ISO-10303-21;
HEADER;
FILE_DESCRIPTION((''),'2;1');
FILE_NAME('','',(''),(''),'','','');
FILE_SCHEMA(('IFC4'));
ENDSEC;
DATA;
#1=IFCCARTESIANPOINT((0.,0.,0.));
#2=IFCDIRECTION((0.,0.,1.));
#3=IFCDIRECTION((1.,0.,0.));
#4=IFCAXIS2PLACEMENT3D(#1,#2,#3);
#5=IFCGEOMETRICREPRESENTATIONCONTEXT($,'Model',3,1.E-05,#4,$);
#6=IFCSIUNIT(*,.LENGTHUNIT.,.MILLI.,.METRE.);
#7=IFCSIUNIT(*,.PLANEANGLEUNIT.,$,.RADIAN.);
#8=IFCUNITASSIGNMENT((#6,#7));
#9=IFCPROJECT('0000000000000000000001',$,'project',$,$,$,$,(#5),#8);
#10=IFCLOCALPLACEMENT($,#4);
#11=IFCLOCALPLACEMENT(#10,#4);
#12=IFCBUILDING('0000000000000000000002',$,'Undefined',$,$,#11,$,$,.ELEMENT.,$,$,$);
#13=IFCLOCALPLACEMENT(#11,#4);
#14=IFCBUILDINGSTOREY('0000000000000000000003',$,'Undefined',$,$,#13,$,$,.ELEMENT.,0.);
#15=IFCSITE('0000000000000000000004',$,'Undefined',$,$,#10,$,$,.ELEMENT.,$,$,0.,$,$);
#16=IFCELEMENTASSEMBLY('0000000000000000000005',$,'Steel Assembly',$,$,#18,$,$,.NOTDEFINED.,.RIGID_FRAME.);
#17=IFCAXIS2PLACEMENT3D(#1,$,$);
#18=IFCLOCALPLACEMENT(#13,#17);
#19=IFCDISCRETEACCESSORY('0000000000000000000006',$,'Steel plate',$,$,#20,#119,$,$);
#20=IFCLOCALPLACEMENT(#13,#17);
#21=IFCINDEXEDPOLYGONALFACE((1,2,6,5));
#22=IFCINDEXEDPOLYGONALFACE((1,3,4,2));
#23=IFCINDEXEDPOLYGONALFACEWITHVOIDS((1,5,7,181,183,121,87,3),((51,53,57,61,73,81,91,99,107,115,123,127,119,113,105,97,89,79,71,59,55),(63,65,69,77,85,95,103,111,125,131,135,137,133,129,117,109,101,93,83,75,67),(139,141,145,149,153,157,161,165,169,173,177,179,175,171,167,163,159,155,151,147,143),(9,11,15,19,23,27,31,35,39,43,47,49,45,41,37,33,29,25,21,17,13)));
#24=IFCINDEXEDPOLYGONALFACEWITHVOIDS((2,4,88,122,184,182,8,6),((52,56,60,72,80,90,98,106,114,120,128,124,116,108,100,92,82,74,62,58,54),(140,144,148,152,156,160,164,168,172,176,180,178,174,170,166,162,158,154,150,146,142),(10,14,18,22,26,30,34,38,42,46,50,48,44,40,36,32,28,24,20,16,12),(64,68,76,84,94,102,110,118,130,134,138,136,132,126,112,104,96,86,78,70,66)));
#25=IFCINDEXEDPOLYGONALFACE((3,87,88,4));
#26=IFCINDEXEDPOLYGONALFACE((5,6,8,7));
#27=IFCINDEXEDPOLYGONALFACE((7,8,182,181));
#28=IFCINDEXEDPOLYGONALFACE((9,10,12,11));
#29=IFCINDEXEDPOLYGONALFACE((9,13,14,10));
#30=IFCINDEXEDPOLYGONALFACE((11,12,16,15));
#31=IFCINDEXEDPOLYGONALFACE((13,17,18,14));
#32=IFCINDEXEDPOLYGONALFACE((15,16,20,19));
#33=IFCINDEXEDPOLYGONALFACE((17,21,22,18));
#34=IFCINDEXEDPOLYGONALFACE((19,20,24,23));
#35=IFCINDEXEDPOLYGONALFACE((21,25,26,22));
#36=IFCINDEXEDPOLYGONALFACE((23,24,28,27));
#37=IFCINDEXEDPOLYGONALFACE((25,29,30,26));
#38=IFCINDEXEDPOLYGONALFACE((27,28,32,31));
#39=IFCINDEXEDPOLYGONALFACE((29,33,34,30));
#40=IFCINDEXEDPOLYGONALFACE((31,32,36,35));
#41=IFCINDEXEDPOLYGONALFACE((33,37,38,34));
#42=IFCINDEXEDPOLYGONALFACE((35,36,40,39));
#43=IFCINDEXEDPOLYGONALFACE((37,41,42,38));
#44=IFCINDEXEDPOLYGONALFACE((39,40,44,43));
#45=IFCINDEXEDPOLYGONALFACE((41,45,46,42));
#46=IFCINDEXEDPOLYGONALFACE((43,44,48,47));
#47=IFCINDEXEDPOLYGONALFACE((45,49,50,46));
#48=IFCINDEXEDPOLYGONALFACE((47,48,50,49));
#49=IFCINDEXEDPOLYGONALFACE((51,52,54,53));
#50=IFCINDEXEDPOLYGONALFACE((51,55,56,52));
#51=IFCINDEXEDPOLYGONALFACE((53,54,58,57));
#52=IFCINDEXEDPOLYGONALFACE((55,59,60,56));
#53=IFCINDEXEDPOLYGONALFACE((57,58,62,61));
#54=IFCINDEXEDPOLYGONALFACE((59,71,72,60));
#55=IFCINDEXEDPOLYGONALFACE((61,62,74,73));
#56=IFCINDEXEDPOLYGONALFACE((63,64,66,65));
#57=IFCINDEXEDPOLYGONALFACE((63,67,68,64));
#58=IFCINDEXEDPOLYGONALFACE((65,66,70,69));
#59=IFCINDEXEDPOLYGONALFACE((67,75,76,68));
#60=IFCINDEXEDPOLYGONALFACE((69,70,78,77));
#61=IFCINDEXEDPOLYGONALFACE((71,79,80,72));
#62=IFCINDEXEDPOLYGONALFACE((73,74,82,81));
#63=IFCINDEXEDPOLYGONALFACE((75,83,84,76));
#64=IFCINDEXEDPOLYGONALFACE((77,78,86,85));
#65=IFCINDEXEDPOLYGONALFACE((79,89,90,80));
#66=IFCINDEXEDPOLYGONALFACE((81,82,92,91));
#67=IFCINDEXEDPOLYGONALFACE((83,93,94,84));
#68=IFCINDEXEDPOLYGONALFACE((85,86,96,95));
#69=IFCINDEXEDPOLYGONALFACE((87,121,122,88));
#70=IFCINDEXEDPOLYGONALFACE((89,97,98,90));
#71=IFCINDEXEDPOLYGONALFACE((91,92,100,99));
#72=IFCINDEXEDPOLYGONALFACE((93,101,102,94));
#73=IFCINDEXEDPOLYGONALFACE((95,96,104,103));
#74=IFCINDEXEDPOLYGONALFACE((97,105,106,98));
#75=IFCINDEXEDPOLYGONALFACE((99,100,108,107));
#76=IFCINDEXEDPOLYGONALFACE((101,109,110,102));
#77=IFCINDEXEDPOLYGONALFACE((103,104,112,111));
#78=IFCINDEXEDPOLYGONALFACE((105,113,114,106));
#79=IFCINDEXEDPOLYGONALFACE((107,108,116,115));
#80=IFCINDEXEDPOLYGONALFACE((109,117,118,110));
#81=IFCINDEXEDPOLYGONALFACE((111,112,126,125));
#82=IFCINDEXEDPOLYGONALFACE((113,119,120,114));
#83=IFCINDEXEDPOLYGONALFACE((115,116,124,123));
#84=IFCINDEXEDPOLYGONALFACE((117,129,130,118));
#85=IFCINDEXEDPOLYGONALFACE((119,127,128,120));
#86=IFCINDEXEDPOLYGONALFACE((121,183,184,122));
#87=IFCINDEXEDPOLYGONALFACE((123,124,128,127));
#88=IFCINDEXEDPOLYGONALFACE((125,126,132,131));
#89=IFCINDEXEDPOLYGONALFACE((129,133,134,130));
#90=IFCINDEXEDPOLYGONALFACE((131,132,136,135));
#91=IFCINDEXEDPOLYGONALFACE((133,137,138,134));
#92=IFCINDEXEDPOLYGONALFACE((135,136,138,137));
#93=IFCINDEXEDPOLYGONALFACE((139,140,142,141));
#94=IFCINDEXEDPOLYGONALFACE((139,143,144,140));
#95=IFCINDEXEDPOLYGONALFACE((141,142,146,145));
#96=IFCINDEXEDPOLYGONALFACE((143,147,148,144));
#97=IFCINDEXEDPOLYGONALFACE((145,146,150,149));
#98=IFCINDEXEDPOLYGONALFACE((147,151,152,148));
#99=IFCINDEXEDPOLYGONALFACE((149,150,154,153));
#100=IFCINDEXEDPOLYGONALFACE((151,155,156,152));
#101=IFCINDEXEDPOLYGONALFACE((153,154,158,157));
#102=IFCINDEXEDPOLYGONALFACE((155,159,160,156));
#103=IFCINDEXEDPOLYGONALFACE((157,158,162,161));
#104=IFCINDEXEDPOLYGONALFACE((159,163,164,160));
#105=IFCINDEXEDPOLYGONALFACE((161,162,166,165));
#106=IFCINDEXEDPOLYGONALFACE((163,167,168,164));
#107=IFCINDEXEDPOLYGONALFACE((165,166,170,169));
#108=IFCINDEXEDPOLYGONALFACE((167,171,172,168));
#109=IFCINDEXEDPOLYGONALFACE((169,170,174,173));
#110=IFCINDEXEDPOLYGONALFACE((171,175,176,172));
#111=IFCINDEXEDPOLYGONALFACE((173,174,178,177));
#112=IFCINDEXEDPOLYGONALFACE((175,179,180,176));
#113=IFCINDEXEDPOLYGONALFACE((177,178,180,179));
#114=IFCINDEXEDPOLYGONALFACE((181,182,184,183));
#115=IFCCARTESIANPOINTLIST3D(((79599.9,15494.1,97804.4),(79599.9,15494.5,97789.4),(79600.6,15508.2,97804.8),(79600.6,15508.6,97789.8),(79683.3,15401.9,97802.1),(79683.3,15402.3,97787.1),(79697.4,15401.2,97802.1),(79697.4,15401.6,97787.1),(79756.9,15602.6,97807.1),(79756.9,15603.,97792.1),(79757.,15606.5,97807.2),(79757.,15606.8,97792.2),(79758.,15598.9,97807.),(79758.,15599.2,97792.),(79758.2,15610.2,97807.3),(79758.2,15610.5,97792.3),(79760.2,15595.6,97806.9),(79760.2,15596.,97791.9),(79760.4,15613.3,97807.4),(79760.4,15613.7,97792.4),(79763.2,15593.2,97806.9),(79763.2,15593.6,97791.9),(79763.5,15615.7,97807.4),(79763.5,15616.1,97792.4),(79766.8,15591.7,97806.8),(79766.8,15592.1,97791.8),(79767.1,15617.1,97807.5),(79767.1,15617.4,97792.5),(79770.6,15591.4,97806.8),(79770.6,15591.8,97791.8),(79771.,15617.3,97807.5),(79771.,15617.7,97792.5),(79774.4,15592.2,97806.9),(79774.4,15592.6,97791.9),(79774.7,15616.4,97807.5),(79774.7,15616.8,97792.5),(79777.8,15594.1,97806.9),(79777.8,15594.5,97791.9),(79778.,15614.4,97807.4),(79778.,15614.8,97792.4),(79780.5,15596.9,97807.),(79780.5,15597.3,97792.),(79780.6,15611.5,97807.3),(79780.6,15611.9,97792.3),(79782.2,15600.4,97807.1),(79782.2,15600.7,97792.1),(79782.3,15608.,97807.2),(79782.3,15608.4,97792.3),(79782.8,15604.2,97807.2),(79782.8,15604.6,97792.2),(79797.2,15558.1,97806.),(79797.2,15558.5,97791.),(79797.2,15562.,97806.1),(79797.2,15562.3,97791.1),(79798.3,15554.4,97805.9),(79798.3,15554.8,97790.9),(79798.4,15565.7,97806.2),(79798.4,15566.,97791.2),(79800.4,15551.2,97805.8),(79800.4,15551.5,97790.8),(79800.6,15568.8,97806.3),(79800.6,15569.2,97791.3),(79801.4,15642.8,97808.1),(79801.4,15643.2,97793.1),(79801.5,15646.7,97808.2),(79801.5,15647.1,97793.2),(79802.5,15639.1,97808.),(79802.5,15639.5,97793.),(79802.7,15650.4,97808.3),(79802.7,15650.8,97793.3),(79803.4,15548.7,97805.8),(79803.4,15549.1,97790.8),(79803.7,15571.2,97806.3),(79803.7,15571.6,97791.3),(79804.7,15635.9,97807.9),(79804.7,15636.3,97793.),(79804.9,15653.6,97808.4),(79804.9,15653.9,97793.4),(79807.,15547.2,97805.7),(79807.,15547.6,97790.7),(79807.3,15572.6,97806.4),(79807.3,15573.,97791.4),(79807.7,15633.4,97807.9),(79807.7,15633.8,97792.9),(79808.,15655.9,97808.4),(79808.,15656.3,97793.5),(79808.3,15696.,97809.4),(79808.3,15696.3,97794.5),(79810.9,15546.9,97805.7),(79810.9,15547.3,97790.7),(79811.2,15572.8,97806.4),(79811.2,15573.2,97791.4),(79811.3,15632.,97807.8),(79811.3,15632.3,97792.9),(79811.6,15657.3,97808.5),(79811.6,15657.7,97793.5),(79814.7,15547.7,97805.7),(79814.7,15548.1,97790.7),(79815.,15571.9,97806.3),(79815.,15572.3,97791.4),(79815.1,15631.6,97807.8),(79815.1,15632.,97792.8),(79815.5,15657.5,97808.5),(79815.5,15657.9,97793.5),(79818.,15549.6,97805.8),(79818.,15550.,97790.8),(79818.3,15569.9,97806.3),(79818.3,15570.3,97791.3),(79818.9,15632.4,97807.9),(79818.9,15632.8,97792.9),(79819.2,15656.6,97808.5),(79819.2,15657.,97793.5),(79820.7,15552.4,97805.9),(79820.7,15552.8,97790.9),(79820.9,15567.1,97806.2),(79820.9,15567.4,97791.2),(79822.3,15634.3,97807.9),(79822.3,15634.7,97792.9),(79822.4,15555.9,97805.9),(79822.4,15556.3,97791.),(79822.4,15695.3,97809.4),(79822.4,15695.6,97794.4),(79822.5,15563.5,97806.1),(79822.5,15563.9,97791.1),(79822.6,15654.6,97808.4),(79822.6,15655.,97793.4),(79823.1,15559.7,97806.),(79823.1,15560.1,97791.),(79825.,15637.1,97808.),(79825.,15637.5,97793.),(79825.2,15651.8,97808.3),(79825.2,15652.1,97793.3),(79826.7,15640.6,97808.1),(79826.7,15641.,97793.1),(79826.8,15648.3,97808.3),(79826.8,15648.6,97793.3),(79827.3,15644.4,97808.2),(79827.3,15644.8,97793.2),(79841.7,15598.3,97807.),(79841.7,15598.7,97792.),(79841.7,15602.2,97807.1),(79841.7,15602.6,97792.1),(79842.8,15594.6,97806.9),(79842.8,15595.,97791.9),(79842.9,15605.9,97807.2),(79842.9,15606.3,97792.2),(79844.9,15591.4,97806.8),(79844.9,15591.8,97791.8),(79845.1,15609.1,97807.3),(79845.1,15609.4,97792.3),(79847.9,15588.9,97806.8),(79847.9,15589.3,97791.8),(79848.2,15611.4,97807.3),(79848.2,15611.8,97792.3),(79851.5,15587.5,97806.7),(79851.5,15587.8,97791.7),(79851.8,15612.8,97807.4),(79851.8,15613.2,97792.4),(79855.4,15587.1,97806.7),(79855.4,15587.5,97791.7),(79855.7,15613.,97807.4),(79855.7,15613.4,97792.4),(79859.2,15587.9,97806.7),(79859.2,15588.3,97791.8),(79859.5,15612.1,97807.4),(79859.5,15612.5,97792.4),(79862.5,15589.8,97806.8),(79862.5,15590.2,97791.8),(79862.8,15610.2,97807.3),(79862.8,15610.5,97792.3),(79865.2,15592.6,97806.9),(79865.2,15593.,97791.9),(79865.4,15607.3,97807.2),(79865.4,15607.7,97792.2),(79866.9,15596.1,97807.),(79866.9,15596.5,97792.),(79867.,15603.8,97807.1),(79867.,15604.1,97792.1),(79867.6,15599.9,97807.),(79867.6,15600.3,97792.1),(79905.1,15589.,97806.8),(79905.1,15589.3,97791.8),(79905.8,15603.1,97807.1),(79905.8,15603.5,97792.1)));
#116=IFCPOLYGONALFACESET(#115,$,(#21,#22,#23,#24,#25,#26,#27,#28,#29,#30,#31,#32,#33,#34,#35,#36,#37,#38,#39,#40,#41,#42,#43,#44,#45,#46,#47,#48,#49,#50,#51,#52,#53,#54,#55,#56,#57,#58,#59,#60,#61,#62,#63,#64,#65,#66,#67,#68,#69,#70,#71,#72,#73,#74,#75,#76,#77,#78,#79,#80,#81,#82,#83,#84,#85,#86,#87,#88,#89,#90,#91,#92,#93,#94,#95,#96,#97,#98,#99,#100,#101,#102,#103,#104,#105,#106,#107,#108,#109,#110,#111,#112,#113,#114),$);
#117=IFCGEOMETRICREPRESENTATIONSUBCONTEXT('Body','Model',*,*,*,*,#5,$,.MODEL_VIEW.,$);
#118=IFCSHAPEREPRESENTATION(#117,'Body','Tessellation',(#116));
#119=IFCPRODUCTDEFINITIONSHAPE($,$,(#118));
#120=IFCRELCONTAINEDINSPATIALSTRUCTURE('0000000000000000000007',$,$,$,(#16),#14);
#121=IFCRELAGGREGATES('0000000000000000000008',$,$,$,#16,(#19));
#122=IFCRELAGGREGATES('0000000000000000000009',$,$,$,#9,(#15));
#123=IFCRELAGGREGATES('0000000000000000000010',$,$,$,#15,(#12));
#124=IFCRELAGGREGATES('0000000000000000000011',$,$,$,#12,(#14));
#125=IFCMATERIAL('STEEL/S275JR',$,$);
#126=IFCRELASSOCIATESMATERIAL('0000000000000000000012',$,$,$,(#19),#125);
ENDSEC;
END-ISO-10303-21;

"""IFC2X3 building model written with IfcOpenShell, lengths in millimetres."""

from ifc_helpers import new_model, si_unit, frame, origin_with_axes, origin_2d_with_axis, place, context, subcontext, project, spatial, polyline, circle, outline, extrude, source, transform, mapped, material, element, aggregate, save


model = new_model("IFC2X3")

# Units and contexts
model_context = context("Model", 3, precision=1e-05, world=origin_with_axes())
body_context = subcontext(model_context, "Body", "Model", "MODEL_VIEW")
ifc_project = project(units=[si_unit("LENGTHUNIT", "METRE", prefix="MILLI"), si_unit("PLANEANGLEUNIT", "RADIAN")], contexts=[model_context])

# Site, building, storey
site_placement = place(None, origin_with_axes())
site = spatial("IfcSite", under=ifc_project, at=site_placement, Name="Undefined", CompositionType="ELEMENT", RefElevation=0.0)
building_placement = place(site_placement, origin_with_axes())
building = spatial("IfcBuilding", under=site, at=building_placement, Name="Undefined", CompositionType="ELEMENT")
storey_placement = place(building_placement, origin_with_axes())
storey = spatial("IfcBuildingStorey", under=building, at=storey_placement, Name="Undefined", CompositionType="ELEMENT", Elevation=0.0)

# Shared definitions
ifc_material_1 = material(Name="STEEL/S275JR")

# Element assembly
assembly_1_placement = place(storey_placement, origin_with_axes())
assembly_1 = element("IfcElementAssembly", 1, at=assembly_1_placement, inside=storey, Name="Steel Assembly", AssemblyPlace="NOTDEFINED", PredefinedType="RIGID_FRAME")

# Discrete accessory, opening
discrete_accessory_1_placement = place(assembly_1_placement, frame((79815.7, 15702.9, 97802.1), z_axis=(0.0, 0.024992, -0.999688), x_axis=(0.670718, -0.741481, -0.018537)))
discrete_accessory_1 = element("IfcDiscreteAccessory", 2, at=discrete_accessory_1_placement, material=ifc_material_1, Name="Steel plate", context=body_context, shape_type="SweptSolid", body=[
    extrude(outline(polyline([(0.0, 10.0), (10.0, 0.0), (134.3, 0.0), (144.3, 10.0), (144.3, 290.0), (134.3, 300.0), (10.0, 300.0), (0.0, 290.0), (0.0, 10.0)])), frame((0.0, 0.0, -7.5), z_axis=(0.0, 0.0, 1.0), x_axis=(1.0, 0.0, 0.0)), (0.0, 0.0, 1.0), 15.0),
])
shared_shape_1 = source(origin_with_axes(), body_context, "Body", "SweptSolid", [
    extrude(circle(Radius=13.0, at=origin_2d_with_axis()), frame((0.0, -10.9, 0.0), z_axis=(0.0, 1.0, 0.0), x_axis=(1.0, 0.0, 0.0)), (0.0, 0.0, 1.0), 26.1),
])
opening_1_placement = place(assembly_1_placement, frame((79834.4, 15622.6, 97796.8), z_axis=(0.670718, -0.741481, -0.018537), x_axis=(-0.741712, -0.670509, -0.016763)))
element("IfcOpeningElement", 3, at=opening_1_placement, cuts=discrete_accessory_1, ObjectType="Opening", context=body_context, shape_type="MappedRepresentation", body=[
    mapped(shared_shape_1, transform((0.0, 0.0, -30.0))),
    mapped(shared_shape_1, transform((60.0, 0.0, -30.0))),
    mapped(shared_shape_1, transform((0.0, 0.0, 30.0))),
    mapped(shared_shape_1, transform((60.0, 0.0, 30.0))),
])
aggregate(assembly_1, [discrete_accessory_1])

save(model, "model.ifc")
